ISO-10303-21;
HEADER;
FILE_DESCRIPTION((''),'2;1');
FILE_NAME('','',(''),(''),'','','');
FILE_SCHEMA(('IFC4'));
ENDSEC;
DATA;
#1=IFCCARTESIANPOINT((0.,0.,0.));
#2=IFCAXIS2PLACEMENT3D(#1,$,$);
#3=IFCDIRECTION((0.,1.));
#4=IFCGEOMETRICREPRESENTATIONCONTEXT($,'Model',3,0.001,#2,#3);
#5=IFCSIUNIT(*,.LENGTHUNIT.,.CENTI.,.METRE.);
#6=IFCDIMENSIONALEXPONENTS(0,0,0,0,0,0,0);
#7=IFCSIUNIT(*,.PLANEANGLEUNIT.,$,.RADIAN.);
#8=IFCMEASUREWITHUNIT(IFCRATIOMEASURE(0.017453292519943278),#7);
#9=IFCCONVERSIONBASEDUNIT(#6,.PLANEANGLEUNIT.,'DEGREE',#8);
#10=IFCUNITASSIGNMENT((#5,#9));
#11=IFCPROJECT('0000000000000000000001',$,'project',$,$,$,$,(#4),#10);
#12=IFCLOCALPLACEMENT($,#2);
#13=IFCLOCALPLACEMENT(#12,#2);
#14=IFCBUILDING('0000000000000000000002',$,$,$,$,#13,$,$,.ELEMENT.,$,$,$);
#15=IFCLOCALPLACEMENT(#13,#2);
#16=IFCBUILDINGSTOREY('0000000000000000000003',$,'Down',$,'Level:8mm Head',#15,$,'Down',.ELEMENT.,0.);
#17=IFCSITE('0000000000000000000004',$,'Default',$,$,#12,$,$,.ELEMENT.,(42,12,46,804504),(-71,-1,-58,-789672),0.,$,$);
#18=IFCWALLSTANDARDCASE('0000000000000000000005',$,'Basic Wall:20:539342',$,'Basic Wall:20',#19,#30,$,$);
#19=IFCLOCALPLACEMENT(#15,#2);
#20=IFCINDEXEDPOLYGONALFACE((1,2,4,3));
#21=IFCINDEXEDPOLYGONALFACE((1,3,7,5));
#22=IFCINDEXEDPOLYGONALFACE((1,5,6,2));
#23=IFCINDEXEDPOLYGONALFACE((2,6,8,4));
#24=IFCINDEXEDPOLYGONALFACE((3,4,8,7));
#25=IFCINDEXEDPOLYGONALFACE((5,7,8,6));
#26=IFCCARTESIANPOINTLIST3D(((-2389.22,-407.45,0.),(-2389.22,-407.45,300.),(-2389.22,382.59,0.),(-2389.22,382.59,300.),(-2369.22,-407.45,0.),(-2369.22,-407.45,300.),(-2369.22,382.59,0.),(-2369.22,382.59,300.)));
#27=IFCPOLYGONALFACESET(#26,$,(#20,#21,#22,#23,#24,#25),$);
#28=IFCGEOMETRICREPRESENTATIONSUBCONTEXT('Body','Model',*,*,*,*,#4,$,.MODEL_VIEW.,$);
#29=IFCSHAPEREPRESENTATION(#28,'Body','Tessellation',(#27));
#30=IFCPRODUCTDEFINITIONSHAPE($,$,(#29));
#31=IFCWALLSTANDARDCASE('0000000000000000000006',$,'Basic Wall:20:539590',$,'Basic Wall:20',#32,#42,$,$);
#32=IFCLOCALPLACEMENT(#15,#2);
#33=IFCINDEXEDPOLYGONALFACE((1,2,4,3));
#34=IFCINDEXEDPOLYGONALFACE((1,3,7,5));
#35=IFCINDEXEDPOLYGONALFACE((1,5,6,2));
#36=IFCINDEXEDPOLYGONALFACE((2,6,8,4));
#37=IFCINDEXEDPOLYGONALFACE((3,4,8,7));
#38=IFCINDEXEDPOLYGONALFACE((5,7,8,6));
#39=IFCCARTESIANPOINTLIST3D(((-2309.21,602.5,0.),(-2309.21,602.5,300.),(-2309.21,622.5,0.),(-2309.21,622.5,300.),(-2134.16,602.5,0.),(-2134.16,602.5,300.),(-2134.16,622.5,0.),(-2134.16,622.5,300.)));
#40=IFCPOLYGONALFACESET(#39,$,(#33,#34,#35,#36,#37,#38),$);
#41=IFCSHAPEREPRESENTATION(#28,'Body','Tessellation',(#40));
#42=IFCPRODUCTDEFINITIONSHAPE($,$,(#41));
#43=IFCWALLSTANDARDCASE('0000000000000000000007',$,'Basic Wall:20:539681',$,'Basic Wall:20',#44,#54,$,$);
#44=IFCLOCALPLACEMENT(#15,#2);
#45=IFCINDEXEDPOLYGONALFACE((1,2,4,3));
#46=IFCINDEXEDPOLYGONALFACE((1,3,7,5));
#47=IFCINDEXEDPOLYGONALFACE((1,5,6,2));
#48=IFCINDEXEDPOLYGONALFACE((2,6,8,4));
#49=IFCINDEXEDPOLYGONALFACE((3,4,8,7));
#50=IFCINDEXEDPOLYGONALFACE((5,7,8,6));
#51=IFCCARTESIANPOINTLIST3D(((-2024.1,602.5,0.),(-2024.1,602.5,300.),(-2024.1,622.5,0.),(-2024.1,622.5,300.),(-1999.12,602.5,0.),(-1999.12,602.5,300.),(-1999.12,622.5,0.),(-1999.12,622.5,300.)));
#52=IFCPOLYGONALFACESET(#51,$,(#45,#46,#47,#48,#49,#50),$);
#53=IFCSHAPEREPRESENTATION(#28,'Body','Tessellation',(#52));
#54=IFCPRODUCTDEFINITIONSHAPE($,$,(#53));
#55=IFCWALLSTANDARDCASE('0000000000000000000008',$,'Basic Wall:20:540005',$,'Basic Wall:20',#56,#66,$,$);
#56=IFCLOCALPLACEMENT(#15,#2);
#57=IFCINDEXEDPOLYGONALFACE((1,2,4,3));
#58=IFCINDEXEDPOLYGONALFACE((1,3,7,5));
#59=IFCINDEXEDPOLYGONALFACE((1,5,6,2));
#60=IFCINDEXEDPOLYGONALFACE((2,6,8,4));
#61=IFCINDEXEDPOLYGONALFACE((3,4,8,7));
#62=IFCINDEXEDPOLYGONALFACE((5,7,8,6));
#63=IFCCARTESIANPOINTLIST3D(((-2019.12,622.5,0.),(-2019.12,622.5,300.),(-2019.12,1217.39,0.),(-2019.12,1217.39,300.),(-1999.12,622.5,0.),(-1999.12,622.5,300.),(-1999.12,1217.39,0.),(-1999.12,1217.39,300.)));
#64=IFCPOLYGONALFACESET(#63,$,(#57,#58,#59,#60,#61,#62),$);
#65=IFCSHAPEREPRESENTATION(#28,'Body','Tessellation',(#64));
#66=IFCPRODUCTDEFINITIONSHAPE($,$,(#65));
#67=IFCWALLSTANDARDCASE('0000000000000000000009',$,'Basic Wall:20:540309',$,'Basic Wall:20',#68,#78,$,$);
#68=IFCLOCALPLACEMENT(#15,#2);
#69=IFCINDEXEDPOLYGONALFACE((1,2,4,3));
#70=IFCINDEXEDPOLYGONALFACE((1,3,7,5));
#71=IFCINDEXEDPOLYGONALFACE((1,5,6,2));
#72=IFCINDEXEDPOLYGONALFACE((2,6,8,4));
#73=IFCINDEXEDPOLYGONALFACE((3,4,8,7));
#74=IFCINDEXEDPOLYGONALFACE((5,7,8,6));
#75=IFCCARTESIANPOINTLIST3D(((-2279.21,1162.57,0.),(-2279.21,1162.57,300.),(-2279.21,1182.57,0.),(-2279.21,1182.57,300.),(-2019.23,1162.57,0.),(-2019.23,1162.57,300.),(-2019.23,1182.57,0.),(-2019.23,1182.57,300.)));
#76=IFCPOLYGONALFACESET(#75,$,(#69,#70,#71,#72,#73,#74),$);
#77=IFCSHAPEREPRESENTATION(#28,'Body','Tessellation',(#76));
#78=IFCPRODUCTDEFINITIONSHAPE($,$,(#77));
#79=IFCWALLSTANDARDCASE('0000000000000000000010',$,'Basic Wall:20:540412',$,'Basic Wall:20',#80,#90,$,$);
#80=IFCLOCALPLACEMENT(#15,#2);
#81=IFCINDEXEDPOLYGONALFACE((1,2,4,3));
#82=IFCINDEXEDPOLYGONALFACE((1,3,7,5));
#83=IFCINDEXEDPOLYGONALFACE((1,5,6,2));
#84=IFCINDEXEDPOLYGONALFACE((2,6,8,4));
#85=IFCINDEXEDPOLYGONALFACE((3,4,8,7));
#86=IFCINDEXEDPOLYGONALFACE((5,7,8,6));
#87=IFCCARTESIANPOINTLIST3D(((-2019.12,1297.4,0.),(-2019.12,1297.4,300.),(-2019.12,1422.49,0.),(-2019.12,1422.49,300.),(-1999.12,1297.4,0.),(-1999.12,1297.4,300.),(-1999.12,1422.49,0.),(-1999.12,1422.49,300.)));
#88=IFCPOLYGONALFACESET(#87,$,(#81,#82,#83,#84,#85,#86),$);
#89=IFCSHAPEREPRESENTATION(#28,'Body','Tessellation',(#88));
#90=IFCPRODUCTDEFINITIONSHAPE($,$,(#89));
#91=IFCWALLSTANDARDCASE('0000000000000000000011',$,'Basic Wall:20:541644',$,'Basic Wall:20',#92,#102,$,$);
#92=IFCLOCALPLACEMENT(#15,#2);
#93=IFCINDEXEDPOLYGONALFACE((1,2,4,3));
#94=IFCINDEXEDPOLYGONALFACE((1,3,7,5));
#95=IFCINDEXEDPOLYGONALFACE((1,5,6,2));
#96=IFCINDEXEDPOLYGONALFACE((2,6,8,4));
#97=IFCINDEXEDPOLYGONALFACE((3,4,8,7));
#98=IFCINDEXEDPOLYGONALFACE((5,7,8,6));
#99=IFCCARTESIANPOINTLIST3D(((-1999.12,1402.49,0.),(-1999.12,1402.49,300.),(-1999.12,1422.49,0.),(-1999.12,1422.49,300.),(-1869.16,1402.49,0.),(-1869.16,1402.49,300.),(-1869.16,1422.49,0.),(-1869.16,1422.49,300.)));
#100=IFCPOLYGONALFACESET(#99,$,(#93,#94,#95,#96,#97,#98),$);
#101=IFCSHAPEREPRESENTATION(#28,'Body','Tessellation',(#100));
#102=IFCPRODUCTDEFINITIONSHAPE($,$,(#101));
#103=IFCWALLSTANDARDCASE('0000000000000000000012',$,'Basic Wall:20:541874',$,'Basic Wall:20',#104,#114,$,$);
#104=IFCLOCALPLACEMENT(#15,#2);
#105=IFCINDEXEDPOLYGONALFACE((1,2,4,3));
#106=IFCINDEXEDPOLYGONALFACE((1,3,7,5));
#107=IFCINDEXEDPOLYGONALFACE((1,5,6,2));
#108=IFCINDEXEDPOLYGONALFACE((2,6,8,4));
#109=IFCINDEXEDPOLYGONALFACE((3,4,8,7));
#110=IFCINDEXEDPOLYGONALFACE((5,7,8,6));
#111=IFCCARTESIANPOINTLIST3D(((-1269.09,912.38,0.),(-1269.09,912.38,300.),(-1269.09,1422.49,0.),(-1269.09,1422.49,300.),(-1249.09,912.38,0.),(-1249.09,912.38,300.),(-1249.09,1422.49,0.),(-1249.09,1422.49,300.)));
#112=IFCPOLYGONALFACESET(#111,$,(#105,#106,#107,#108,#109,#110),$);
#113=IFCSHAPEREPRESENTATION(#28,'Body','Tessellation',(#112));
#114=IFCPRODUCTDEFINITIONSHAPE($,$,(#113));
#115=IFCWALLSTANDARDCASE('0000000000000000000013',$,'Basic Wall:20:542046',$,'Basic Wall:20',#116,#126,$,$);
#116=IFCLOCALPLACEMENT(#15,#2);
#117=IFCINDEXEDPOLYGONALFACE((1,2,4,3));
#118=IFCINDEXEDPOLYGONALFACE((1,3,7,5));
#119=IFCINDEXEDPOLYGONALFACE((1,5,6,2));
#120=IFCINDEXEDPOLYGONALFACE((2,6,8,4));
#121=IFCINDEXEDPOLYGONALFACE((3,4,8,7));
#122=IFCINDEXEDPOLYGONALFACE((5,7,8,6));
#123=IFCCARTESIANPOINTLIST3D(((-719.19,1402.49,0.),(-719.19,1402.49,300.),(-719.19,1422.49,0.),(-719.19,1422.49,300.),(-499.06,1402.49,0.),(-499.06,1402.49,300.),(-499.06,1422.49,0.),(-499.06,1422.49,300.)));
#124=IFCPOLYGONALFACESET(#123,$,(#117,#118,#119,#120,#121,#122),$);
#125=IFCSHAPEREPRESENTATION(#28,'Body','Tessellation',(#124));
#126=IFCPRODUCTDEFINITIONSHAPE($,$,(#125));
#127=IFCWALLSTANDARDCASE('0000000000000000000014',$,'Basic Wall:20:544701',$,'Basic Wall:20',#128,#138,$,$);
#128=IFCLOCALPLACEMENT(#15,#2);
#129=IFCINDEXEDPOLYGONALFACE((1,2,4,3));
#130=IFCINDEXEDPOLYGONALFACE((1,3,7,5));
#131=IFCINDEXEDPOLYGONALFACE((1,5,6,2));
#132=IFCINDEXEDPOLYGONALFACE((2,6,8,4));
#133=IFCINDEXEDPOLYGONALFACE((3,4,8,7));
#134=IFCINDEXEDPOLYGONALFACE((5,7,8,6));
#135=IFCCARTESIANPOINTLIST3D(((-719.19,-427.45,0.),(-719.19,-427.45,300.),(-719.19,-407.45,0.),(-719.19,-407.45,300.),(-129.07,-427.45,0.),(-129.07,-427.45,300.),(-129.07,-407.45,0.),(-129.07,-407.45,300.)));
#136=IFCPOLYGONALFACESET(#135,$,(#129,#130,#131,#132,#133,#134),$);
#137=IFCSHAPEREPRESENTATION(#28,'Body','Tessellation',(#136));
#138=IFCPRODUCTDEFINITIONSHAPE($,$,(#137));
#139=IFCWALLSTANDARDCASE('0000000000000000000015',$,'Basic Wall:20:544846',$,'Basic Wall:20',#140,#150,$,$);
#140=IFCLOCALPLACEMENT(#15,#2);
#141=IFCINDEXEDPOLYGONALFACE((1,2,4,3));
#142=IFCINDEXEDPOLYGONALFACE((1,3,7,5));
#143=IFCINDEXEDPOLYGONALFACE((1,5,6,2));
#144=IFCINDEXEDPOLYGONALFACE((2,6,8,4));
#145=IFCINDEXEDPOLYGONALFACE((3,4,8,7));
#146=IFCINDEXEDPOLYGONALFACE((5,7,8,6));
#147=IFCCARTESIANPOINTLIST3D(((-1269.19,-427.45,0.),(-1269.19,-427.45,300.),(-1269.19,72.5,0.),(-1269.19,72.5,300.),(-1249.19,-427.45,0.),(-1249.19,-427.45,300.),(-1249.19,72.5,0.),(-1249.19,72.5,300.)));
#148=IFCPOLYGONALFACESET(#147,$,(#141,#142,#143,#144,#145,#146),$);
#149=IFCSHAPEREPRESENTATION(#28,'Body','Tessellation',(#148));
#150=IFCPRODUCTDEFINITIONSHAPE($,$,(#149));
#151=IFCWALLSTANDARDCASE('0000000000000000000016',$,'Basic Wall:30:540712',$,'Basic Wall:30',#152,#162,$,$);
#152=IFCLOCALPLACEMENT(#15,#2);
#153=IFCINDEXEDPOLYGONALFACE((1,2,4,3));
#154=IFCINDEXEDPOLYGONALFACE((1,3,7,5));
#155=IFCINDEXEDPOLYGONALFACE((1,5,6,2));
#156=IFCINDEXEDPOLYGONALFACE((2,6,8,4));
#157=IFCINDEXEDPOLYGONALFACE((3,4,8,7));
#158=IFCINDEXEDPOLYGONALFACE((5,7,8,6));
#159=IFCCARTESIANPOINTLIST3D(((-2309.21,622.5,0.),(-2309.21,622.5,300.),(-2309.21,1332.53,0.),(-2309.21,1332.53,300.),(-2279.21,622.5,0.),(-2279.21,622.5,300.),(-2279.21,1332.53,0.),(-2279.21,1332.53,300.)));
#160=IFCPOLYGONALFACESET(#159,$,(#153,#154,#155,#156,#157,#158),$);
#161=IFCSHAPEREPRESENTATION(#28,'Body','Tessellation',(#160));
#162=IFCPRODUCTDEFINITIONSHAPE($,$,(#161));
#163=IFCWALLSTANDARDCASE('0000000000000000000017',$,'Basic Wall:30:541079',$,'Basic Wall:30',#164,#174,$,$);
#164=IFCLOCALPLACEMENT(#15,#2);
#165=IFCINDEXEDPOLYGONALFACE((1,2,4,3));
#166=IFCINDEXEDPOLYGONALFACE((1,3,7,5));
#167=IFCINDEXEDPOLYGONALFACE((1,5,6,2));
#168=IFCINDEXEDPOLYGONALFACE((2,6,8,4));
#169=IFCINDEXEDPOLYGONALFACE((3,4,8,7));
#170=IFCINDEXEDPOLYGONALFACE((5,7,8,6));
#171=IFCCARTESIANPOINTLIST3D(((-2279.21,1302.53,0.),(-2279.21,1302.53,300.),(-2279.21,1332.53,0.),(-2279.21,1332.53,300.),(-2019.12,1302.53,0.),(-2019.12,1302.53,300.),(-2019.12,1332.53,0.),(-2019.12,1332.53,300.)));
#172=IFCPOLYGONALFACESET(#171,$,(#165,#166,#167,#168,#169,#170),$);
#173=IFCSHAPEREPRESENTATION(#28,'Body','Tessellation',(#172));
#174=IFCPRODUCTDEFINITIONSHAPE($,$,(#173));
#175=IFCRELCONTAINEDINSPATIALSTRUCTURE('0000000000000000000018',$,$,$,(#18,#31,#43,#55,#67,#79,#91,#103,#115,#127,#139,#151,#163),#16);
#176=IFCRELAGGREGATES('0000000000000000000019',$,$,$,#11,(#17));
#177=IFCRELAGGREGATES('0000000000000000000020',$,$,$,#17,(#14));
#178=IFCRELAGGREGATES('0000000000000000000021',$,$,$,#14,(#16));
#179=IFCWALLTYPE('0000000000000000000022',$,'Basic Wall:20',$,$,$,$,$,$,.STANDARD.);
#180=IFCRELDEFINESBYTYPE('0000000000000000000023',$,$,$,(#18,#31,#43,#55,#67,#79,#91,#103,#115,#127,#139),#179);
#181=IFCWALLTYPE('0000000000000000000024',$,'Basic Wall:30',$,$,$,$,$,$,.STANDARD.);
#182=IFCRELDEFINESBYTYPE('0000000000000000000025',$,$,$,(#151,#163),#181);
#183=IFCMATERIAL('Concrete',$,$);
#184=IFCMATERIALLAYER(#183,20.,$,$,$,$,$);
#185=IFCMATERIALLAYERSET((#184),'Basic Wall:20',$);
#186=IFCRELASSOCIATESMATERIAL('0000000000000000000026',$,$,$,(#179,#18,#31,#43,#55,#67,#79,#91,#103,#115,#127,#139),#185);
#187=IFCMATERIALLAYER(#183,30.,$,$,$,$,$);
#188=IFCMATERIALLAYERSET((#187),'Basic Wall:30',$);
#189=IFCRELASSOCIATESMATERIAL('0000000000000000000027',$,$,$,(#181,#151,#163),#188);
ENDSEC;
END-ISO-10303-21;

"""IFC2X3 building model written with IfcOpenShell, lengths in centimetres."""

from ifc_helpers import new_model, entity, si_unit, converted_unit, direction, frame, frame_2d, origin, place, context, subcontext, project, spatial, rectangle, extrude, material, layer, layer_set, layer_usage, type_object, element, save


model = new_model("IFC2X3")

# Units and contexts
model_context = context("Model", 3, precision=0.001, world=origin(), true_north=direction((0.0, 1.0)))
body_context = subcontext(model_context, "Body", "Model", "MODEL_VIEW")
ifc_project = project(units=[si_unit("LENGTHUNIT", "METRE", prefix="CENTI"), converted_unit("PLANEANGLEUNIT", "DEGREE", entity("IfcRatioMeasure", 0.017453292519943278), si_unit("PLANEANGLEUNIT", "RADIAN"), dimensions=[0, 0, 0, 0, 0, 0, 0])], contexts=[model_context])

# Site, building, storey
site_placement = place(None, origin())
site = spatial("IfcSite", under=ifc_project, at=site_placement, Name="Default", CompositionType="ELEMENT", RefLatitude=(42, 12, 46, 804504), RefLongitude=(-71, -1, -58, -789672), RefElevation=0.0)
building_placement = place(site_placement, origin())
building = spatial("IfcBuilding", under=site, at=building_placement, CompositionType="ELEMENT")
storey_placement = place(building_placement, origin())
storey = spatial("IfcBuildingStorey", under=building, at=storey_placement, Name="Down", ObjectType="Level:8mm Head", LongName="Down", CompositionType="ELEMENT", Elevation=0.0)

# Shared definitions
ifc_material = material(Name="Concrete")

# Walls
ifc_layer_1 = layer(ifc_material, 20.0)
ifc_layer_set_1 = layer_set([ifc_layer_1], Name="Basic Wall:20")
wall_type_1 = type_object("IfcWallType", Name="Basic Wall:20", PredefinedType="STANDARD", material=ifc_layer_set_1)
ifc_layer_usage_1 = layer_usage(ifc_layer_set_1, "AXIS2", "NEGATIVE", 10.0)
wall_1_placement = place(storey_placement, frame((-2379.22, -407.45, 0.0), z_axis=(0.0, 0.0, 1.0), x_axis=(0.0, 1.0, 0.0)))
element("IfcWallStandardCase", 1, at=wall_1_placement, inside=storey, type_object=wall_type_1, material=ifc_layer_usage_1, Name="Basic Wall:20:539342", ObjectType="Basic Wall:20", context=body_context, shape_type="SweptSolid", body=[
    extrude(rectangle(XDim=790.04, YDim=20.0, at=frame_2d((395.02, 0.0), x_axis=(-1.0, 0.0))), origin(), (0.0, 0.0, 1.0), 300.0),
])
ifc_layer_usage_2 = layer_usage(ifc_layer_set_1, "AXIS2", "POSITIVE", -10.0)
wall_2_placement = place(storey_placement, frame((-2309.21, 612.5, 0.0)))
element("IfcWallStandardCase", 2, at=wall_2_placement, inside=storey, type_object=wall_type_1, material=ifc_layer_usage_2, Name="Basic Wall:20:539590", ObjectType="Basic Wall:20", context=body_context, shape_type="SweptSolid", body=[
    extrude(rectangle(XDim=175.05, YDim=20.0, at=frame_2d((87.52, 0.0), x_axis=(-1.0, 0.0))), origin(), (0.0, 0.0, 1.0), 300.0),
])
ifc_layer_usage_3 = layer_usage(ifc_layer_set_1, "AXIS2", "POSITIVE", -10.0)
wall_3_placement = place(storey_placement, frame((-2024.1, 612.5, 0.0)))
element("IfcWallStandardCase", 3, at=wall_3_placement, inside=storey, type_object=wall_type_1, material=ifc_layer_usage_3, Name="Basic Wall:20:539681", ObjectType="Basic Wall:20", context=body_context, shape_type="SweptSolid", body=[
    extrude(rectangle(XDim=24.98, YDim=20.0, at=frame_2d((12.49, 0.0), x_axis=(-1.0, 0.0))), origin(), (0.0, 0.0, 1.0), 300.0),
])
ifc_layer_usage_4 = layer_usage(ifc_layer_set_1, "AXIS2", "POSITIVE", -10.0)
wall_4_placement = place(storey_placement, frame((-2009.12, 622.5, 0.0), z_axis=(0.0, 0.0, 1.0), x_axis=(0.0, 1.0, 0.0)))
element("IfcWallStandardCase", 4, at=wall_4_placement, inside=storey, type_object=wall_type_1, material=ifc_layer_usage_4, Name="Basic Wall:20:540005", ObjectType="Basic Wall:20", context=body_context, shape_type="SweptSolid", body=[
    extrude(rectangle(XDim=594.88, YDim=20.0, at=frame_2d((297.44, 0.0), x_axis=(-1.0, 0.0))), origin(), (0.0, 0.0, 1.0), 300.0),
])
ifc_layer_usage_5 = layer_usage(ifc_layer_set_1, "AXIS2", "NEGATIVE", 10.0)
wall_5_placement = place(storey_placement, frame((-2019.23, 1172.57, 0.0), z_axis=(0.0, 0.0, 1.0), x_axis=(-1.0, 0.0, 0.0)))
element("IfcWallStandardCase", 5, at=wall_5_placement, inside=storey, type_object=wall_type_1, material=ifc_layer_usage_5, Name="Basic Wall:20:540309", ObjectType="Basic Wall:20", context=body_context, shape_type="SweptSolid", body=[
    extrude(rectangle(XDim=259.98, YDim=20.0, at=frame_2d((129.99, 0.0), x_axis=(-1.0, 0.0))), origin(), (0.0, 0.0, 1.0), 300.0),
])
ifc_layer_usage_6 = layer_usage(ifc_layer_set_1, "AXIS2", "POSITIVE", -10.0)
wall_6_placement = place(storey_placement, frame((-2009.12, 1297.4, 0.0), z_axis=(0.0, 0.0, 1.0), x_axis=(0.0, 1.0, 0.0)))
element("IfcWallStandardCase", 6, at=wall_6_placement, inside=storey, type_object=wall_type_1, material=ifc_layer_usage_6, Name="Basic Wall:20:540412", ObjectType="Basic Wall:20", context=body_context, shape_type="SweptSolid", body=[
    extrude(rectangle(XDim=125.09, YDim=20.0, at=frame_2d((62.55, 0.0), x_axis=(-1.0, 0.0))), origin(), (0.0, 0.0, 1.0), 300.0),
])
ifc_layer_usage_7 = layer_usage(ifc_layer_set_1, "AXIS2", "NEGATIVE", 10.0)
wall_7_placement = place(storey_placement, frame((-1999.12, 1412.49, 0.0)))
element("IfcWallStandardCase", 7, at=wall_7_placement, inside=storey, type_object=wall_type_1, material=ifc_layer_usage_7, Name="Basic Wall:20:541644", ObjectType="Basic Wall:20", context=body_context, shape_type="SweptSolid", body=[
    extrude(rectangle(XDim=129.96, YDim=20.0, at=frame_2d((64.98, 0.0), x_axis=(-1.0, 0.0))), origin(), (0.0, 0.0, 1.0), 300.0),
])
ifc_layer_usage_8 = layer_usage(ifc_layer_set_1, "AXIS2", "POSITIVE", -10.0)
wall_8_placement = place(storey_placement, frame((-1259.09, 1422.49, 0.0), z_axis=(0.0, 0.0, 1.0), x_axis=(0.0, -1.0, 0.0)))
element("IfcWallStandardCase", 8, at=wall_8_placement, inside=storey, type_object=wall_type_1, material=ifc_layer_usage_8, Name="Basic Wall:20:541874", ObjectType="Basic Wall:20", context=body_context, shape_type="SweptSolid", body=[
    extrude(rectangle(XDim=510.11, YDim=20.0, at=frame_2d((255.06, 0.0), x_axis=(-1.0, 0.0))), origin(), (0.0, 0.0, 1.0), 300.0),
])
ifc_layer_usage_9 = layer_usage(ifc_layer_set_1, "AXIS2", "POSITIVE", -10.0)
wall_9_placement = place(storey_placement, frame((-719.19, 1412.49, 0.0)))
element("IfcWallStandardCase", 9, at=wall_9_placement, inside=storey, type_object=wall_type_1, material=ifc_layer_usage_9, Name="Basic Wall:20:542046", ObjectType="Basic Wall:20", context=body_context, shape_type="SweptSolid", body=[
    extrude(rectangle(XDim=220.13, YDim=20.0, at=frame_2d((110.07, 0.0), x_axis=(-1.0, 0.0))), origin(), (0.0, 0.0, 1.0), 300.0),
])
ifc_layer_usage_10 = layer_usage(ifc_layer_set_1, "AXIS2", "NEGATIVE", 10.0)
wall_10_placement = place(storey_placement, frame((-129.07, -417.45, 0.0), z_axis=(0.0, 0.0, 1.0), x_axis=(-1.0, 0.0, 0.0)))
element("IfcWallStandardCase", 10, at=wall_10_placement, inside=storey, type_object=wall_type_1, material=ifc_layer_usage_10, Name="Basic Wall:20:544701", ObjectType="Basic Wall:20", context=body_context, shape_type="SweptSolid", body=[
    extrude(rectangle(XDim=590.12, YDim=20.0, at=frame_2d((295.06, 0.0), x_axis=(-1.0, 0.0))), origin(), (0.0, 0.0, 1.0), 300.0),
])
ifc_layer_usage_11 = layer_usage(ifc_layer_set_1, "AXIS2", "NEGATIVE", 10.0)
wall_11_placement = place(storey_placement, frame((-1259.19, 72.5, 0.0), z_axis=(0.0, 0.0, 1.0), x_axis=(0.0, -1.0, 0.0)))
element("IfcWallStandardCase", 11, at=wall_11_placement, inside=storey, type_object=wall_type_1, material=ifc_layer_usage_11, Name="Basic Wall:20:544846", ObjectType="Basic Wall:20", context=body_context, shape_type="SweptSolid", body=[
    extrude(rectangle(XDim=499.95, YDim=20.0, at=frame_2d((249.98, 0.0), x_axis=(-1.0, 0.0))), origin(), (0.0, 0.0, 1.0), 300.0),
])
ifc_layer_2 = layer(ifc_material, 30.0)
ifc_layer_set_2 = layer_set([ifc_layer_2], Name="Basic Wall:30")
ifc_layer_usage_12 = layer_usage(ifc_layer_set_2, "AXIS2", "NEGATIVE", 15.0)
wall_type_2 = type_object("IfcWallType", Name="Basic Wall:30", PredefinedType="STANDARD", material=ifc_layer_set_2)
wall_12_placement = place(storey_placement, frame((-2294.21, 622.5, 0.0), z_axis=(0.0, 0.0, 1.0), x_axis=(0.0, 1.0, 0.0)))
element("IfcWallStandardCase", 12, at=wall_12_placement, inside=storey, type_object=wall_type_2, material=ifc_layer_usage_12, Name="Basic Wall:30:540712", ObjectType="Basic Wall:30", context=body_context, shape_type="SweptSolid", body=[
    extrude(rectangle(XDim=710.03, YDim=30.0, at=frame_2d((355.01, 0.0), x_axis=(-1.0, 0.0))), origin(), (0.0, 0.0, 1.0), 300.0),
])
ifc_layer_usage_13 = layer_usage(ifc_layer_set_2, "AXIS2", "NEGATIVE", 15.0)
wall_13_placement = place(storey_placement, frame((-2279.21, 1317.53, 0.0)))
element("IfcWallStandardCase", 13, at=wall_13_placement, inside=storey, type_object=wall_type_2, material=ifc_layer_usage_13, Name="Basic Wall:30:541079", ObjectType="Basic Wall:30", context=body_context, shape_type="SweptSolid", body=[
    extrude(rectangle(XDim=260.09, YDim=30.0, at=frame_2d((130.04, 0.0), x_axis=(-1.0, 0.0))), origin(), (0.0, 0.0, 1.0), 300.0),
])

save(model, "model.ifc")
